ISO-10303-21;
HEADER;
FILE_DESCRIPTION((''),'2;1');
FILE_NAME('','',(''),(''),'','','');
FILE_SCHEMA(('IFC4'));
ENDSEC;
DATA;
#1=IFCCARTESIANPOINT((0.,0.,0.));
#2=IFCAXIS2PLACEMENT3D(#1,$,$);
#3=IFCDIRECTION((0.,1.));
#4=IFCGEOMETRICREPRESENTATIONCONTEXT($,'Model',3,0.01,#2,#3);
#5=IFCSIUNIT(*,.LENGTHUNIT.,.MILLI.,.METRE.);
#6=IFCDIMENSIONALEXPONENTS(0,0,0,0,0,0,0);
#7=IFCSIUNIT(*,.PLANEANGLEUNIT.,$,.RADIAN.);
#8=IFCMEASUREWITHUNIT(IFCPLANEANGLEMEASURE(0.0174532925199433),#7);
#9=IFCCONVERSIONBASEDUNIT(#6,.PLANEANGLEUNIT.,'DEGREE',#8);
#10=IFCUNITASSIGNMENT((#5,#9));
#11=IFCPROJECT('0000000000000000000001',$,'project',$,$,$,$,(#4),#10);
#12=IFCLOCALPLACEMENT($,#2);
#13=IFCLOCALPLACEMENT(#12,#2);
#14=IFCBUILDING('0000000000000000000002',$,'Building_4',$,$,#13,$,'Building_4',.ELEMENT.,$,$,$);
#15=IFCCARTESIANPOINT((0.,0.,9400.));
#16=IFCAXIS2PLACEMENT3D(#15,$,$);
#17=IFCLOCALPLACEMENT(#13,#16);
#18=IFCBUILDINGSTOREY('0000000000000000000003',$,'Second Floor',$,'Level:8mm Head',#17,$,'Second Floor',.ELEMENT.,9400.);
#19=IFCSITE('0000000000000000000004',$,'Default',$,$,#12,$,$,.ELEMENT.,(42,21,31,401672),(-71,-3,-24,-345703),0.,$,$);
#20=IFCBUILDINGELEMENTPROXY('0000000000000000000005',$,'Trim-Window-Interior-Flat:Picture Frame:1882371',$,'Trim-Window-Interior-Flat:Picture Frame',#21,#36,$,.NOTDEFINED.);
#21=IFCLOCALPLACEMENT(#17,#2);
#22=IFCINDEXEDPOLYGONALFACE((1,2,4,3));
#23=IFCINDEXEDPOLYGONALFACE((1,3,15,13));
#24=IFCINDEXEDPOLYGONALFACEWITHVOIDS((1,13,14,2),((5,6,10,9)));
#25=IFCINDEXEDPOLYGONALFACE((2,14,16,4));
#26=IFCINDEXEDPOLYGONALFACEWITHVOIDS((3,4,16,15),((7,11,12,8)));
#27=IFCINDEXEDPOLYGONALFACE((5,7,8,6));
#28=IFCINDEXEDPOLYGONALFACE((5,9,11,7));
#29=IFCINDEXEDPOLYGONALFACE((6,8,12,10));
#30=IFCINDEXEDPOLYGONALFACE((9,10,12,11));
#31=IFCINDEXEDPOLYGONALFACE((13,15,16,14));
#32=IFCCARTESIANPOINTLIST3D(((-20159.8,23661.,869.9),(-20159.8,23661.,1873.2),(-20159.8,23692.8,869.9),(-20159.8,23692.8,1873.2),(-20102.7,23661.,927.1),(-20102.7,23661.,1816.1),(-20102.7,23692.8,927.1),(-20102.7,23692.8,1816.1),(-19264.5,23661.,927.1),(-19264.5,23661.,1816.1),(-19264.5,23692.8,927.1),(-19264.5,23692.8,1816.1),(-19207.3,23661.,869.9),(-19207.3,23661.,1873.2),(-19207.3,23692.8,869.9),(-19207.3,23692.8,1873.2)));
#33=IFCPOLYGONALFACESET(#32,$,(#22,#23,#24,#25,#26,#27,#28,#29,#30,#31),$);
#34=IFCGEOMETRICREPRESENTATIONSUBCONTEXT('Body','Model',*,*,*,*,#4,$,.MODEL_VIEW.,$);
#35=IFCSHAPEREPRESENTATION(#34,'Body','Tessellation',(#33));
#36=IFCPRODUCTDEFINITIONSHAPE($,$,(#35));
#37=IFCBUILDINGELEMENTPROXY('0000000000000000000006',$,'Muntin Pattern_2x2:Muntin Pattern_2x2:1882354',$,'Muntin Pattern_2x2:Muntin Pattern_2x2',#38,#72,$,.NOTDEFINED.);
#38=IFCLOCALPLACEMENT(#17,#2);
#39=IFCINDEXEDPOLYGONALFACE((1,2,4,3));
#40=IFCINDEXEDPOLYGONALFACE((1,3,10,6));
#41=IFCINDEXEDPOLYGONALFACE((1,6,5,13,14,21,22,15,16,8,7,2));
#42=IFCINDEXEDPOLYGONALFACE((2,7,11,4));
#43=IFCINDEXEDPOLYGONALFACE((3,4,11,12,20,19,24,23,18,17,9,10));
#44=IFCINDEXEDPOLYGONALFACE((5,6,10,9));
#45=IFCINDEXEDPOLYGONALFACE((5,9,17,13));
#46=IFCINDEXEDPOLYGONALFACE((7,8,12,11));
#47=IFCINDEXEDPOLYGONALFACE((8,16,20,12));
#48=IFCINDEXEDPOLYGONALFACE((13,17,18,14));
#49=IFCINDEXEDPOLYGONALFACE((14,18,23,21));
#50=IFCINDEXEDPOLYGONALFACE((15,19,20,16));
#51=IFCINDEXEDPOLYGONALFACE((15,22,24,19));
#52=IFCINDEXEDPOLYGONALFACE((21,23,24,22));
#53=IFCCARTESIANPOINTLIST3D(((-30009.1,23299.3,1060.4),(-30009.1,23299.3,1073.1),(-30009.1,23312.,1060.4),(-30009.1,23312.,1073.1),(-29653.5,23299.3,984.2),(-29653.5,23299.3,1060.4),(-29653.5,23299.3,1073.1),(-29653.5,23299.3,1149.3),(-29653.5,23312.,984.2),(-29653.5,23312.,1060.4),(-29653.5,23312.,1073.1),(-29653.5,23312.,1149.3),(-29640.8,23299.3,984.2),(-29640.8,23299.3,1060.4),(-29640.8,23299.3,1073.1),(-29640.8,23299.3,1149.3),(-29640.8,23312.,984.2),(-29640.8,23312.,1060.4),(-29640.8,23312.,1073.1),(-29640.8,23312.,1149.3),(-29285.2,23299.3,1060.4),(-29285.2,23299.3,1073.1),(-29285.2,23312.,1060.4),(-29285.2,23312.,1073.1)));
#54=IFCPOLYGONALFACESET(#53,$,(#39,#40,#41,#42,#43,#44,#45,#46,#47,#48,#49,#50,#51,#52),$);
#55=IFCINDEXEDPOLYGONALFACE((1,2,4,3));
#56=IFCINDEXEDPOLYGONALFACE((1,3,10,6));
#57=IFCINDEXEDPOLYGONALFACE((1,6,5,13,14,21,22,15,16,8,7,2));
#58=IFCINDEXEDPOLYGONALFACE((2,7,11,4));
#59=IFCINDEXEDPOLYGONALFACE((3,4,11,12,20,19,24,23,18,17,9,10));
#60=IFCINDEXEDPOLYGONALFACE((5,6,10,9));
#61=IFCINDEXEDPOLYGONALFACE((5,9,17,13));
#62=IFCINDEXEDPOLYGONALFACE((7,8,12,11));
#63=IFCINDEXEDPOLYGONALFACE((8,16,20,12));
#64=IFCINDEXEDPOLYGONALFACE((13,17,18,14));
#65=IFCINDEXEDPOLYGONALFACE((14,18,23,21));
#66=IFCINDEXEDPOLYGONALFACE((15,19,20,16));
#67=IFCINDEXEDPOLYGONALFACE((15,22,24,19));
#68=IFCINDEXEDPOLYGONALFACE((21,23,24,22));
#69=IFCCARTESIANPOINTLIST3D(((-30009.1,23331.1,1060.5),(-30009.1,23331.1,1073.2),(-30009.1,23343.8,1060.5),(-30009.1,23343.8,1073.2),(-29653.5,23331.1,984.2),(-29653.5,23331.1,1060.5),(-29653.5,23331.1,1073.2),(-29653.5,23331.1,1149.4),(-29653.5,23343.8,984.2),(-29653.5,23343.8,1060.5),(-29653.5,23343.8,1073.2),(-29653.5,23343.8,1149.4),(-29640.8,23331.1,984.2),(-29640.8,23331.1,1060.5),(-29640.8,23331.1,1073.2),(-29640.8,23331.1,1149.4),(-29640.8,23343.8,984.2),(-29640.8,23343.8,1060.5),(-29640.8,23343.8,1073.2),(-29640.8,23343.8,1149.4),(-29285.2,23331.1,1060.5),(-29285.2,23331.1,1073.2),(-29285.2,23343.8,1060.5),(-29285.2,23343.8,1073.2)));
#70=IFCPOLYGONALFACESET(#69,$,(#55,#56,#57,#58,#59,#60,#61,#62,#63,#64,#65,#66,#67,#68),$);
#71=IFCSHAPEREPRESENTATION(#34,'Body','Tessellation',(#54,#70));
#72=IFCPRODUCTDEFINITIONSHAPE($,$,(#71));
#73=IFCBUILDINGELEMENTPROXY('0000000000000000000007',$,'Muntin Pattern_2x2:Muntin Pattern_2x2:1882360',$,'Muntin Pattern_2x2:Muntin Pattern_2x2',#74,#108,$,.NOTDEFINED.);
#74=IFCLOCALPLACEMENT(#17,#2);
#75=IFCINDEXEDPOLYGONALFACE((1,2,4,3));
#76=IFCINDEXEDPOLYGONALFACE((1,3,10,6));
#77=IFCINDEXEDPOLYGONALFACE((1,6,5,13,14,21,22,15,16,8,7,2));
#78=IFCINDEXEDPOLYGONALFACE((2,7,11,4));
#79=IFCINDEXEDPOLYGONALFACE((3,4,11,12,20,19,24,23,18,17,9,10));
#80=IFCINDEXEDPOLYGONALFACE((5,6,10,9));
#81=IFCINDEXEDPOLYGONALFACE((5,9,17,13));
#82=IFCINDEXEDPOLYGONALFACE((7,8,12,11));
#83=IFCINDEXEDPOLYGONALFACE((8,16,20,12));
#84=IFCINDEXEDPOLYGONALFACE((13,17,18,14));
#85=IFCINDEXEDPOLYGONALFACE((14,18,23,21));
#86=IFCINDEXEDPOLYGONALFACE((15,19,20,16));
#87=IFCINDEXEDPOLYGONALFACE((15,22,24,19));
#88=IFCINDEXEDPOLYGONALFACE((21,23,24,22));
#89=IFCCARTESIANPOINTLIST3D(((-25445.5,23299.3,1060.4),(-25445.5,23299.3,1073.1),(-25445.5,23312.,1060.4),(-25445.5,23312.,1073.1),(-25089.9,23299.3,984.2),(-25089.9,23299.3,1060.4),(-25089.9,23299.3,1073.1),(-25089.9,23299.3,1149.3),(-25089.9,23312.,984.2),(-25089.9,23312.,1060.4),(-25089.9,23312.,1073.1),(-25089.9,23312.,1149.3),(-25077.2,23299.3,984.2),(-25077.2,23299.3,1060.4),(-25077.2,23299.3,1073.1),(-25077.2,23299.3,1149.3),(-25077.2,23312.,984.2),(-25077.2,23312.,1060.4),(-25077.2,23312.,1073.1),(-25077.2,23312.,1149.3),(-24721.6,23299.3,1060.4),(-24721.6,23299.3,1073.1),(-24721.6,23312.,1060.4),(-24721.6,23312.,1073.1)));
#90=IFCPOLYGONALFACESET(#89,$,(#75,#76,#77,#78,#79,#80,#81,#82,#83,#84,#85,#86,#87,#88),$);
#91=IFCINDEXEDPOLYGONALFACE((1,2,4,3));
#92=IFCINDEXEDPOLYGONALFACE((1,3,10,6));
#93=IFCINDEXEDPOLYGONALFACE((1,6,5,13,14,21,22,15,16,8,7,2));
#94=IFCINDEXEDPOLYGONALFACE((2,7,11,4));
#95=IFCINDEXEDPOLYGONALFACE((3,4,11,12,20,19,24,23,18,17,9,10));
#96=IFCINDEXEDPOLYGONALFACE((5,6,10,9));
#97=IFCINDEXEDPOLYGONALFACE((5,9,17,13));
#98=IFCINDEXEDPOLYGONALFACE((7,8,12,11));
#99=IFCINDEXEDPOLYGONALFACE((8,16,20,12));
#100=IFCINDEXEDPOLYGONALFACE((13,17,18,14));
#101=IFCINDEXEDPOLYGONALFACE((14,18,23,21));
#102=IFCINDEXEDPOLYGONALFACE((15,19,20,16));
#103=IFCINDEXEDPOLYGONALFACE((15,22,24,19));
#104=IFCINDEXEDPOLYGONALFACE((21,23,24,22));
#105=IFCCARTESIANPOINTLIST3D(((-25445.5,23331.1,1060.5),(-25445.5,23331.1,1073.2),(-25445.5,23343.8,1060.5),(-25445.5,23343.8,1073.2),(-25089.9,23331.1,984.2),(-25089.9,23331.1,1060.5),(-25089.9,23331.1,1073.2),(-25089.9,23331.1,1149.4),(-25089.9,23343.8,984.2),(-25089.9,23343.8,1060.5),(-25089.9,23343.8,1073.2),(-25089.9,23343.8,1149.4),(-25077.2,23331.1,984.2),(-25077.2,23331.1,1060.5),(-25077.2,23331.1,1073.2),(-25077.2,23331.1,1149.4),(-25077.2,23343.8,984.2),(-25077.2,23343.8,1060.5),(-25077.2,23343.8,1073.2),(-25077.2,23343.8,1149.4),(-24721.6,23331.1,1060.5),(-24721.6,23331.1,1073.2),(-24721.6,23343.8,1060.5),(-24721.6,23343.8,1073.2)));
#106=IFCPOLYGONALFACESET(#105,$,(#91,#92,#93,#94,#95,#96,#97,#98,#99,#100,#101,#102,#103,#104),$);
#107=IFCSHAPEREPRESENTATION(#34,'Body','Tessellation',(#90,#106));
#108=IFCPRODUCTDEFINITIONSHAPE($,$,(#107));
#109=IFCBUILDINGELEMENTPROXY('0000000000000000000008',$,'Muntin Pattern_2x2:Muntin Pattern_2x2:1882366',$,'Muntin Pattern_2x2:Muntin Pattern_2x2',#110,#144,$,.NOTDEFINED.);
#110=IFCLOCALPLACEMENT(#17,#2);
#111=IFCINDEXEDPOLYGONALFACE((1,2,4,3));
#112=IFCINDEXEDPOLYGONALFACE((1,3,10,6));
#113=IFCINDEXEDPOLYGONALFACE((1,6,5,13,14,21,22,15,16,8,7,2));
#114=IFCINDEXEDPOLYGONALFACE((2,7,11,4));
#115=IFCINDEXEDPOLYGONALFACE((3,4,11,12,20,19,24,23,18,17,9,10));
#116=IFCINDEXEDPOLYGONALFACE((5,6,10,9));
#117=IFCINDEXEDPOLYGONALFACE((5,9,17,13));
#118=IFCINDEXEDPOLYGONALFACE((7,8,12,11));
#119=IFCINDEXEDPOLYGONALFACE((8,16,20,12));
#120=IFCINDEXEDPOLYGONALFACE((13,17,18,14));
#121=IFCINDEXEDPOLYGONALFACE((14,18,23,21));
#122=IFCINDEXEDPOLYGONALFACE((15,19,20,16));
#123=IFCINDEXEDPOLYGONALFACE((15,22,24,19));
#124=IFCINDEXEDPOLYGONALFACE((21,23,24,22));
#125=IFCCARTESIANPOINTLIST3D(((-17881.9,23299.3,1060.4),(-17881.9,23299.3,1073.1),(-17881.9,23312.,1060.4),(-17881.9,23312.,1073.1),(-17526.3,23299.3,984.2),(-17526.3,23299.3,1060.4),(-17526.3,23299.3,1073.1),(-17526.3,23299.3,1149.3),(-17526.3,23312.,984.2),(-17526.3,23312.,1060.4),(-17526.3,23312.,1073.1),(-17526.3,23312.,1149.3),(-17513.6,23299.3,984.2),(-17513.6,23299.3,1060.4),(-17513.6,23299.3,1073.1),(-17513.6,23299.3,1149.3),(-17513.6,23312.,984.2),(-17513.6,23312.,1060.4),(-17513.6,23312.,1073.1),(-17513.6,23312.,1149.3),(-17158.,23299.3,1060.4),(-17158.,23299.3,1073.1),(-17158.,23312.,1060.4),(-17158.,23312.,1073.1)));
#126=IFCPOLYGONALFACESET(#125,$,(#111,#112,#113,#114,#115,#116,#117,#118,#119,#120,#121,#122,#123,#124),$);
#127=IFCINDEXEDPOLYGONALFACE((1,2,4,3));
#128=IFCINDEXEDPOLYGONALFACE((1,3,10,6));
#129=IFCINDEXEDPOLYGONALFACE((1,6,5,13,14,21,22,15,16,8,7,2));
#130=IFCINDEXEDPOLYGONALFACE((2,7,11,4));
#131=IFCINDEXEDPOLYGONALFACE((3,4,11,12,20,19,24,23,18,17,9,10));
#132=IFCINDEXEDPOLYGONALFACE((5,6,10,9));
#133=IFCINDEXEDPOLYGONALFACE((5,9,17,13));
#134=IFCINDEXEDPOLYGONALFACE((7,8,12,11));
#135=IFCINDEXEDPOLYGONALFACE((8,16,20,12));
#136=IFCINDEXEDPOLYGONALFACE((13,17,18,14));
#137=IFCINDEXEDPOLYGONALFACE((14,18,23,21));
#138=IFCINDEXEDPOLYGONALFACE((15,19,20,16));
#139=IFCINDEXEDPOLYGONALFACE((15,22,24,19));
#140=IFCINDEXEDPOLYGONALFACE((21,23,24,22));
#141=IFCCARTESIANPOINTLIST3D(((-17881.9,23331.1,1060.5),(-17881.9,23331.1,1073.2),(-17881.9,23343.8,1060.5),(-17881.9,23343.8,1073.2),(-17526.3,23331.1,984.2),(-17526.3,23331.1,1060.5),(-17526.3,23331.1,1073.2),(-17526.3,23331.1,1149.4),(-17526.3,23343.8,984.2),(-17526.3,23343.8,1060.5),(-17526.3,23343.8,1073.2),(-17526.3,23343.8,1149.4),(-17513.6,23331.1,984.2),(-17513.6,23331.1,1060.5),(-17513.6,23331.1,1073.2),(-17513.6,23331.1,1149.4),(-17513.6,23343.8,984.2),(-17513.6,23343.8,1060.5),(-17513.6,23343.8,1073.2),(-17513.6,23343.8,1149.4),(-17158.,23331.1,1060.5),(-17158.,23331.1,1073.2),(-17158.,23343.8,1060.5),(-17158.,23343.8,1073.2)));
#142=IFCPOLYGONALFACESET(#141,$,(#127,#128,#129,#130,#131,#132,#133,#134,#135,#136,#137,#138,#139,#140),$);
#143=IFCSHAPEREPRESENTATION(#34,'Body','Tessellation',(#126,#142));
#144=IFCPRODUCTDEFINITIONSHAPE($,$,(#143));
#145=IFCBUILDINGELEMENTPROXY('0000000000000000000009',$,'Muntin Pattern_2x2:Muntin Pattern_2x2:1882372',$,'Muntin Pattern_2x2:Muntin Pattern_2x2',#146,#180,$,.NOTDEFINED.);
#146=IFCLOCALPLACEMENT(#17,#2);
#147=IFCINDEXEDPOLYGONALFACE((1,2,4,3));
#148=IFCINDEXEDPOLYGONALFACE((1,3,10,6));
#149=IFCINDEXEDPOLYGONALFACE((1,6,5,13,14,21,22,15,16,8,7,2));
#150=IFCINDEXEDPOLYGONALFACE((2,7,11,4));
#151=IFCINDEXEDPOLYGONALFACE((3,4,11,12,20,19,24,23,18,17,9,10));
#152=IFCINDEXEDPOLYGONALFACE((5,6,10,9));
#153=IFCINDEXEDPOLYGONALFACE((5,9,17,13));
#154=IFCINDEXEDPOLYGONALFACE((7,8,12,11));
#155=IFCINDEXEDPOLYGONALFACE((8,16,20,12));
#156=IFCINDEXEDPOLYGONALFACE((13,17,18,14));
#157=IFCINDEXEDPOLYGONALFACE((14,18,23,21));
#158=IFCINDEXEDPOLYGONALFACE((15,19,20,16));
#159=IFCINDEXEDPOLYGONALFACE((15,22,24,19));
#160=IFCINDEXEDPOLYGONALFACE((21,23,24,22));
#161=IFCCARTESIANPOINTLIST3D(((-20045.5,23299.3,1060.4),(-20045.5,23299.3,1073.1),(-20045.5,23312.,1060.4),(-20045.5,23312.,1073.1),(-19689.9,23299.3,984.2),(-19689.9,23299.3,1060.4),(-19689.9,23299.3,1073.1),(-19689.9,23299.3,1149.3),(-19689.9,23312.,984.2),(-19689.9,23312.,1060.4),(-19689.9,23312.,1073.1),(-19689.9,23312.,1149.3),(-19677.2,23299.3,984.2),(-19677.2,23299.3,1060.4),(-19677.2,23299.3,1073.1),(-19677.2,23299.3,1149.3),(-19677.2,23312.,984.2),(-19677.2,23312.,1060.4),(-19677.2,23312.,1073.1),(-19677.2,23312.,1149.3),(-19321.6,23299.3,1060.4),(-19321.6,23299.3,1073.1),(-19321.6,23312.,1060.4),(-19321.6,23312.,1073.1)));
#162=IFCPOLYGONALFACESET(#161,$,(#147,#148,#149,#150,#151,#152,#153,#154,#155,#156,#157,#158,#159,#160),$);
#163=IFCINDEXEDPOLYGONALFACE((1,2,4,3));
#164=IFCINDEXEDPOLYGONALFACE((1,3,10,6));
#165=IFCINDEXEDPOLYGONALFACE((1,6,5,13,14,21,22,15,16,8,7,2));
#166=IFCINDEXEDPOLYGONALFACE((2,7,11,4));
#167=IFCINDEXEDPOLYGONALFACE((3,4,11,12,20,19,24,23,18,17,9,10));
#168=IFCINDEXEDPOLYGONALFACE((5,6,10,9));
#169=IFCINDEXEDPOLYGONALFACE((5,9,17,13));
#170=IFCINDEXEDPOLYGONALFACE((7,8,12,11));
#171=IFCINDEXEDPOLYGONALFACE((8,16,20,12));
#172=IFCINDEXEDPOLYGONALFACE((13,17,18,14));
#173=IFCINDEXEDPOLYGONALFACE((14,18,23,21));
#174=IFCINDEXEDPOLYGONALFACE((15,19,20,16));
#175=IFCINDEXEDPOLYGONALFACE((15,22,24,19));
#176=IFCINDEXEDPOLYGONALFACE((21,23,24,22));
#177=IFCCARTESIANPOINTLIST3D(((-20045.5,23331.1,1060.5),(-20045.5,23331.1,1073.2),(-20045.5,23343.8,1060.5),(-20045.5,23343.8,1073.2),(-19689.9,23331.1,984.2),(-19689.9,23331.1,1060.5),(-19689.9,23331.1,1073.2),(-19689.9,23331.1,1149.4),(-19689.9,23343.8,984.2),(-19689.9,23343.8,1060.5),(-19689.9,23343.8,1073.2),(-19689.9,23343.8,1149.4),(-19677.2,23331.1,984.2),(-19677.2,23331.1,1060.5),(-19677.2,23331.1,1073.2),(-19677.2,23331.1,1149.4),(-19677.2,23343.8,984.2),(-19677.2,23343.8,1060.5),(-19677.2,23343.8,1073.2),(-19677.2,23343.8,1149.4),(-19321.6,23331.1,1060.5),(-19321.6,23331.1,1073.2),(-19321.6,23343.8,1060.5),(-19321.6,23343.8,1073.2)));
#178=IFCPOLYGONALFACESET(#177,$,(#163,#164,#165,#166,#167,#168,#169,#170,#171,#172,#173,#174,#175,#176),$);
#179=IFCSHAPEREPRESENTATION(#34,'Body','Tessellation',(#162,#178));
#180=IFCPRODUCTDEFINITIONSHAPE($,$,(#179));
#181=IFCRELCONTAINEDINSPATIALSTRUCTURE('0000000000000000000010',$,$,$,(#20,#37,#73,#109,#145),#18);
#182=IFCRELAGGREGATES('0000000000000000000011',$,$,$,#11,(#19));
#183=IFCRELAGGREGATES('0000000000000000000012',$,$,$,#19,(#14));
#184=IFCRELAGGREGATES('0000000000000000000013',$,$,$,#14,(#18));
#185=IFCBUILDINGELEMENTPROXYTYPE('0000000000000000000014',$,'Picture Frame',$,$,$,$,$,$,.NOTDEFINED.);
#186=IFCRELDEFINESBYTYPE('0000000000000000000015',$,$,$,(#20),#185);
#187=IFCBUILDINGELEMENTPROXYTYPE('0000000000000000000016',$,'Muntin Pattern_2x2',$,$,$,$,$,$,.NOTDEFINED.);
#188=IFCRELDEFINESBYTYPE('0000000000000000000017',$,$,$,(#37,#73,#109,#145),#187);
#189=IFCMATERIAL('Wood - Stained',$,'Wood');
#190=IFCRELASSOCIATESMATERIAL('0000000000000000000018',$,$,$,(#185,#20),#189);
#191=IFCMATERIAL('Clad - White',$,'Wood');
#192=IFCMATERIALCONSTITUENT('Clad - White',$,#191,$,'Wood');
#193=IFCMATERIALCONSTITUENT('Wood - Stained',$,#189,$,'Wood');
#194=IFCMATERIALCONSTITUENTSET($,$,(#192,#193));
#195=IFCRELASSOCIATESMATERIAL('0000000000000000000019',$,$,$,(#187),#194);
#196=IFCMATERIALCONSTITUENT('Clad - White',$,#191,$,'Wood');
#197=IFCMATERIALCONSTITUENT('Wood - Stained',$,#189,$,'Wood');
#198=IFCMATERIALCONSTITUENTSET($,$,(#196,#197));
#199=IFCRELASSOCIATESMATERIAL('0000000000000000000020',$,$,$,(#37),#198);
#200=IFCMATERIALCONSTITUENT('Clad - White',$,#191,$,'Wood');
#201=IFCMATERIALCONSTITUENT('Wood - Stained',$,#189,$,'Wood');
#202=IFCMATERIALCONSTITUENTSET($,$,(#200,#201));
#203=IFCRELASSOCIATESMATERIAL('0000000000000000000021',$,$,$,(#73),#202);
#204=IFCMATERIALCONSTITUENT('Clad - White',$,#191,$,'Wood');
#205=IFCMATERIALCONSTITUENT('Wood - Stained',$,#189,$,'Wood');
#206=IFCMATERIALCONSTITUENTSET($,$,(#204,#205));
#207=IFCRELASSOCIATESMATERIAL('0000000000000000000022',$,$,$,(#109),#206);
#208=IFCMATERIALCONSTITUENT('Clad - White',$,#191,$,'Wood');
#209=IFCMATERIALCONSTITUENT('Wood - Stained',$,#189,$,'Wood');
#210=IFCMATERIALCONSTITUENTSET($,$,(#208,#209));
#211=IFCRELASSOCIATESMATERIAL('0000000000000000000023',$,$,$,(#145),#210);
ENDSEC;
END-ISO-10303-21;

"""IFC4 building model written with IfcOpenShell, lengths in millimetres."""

from ifc_helpers import new_model, entity, si_unit, converted_unit, direction, frame, origin, place, context, subcontext, project, spatial, indexed_curve, outline, extrude, source, transform, mapped, material, constituent, constituent_set, type_object, type_shapes, element, save


model = new_model("IFC4")

# Units and contexts
model_context = context("Model", 3, precision=0.01, world=origin(), true_north=direction((0.0, 1.0)))
body_context = subcontext(model_context, "Body", "Model", "MODEL_VIEW")
ifc_project = project(units=[si_unit("LENGTHUNIT", "METRE", prefix="MILLI"), converted_unit("PLANEANGLEUNIT", "DEGREE", entity("IfcPlaneAngleMeasure", 0.0174532925199433), si_unit("PLANEANGLEUNIT", "RADIAN"), dimensions=[0, 0, 0, 0, 0, 0, 0])], contexts=[model_context])

# Site, building, storey
site_placement = place(None, origin())
site = spatial("IfcSite", under=ifc_project, at=site_placement, Name="Default", CompositionType="ELEMENT", RefLatitude=(42, 21, 31, 401672), RefLongitude=(-71, -3, -24, -345703), RefElevation=0.0)
building_placement = place(site_placement, origin())
building = spatial("IfcBuilding", under=site, at=building_placement, Name="Building_4", LongName="Building_4", CompositionType="ELEMENT")
storey_placement = place(building_placement, frame((0.0, 0.0, 9400.0)))
storey = spatial("IfcBuildingStorey", under=building, at=storey_placement, Name="Second Floor", ObjectType="Level:8mm Head", LongName="Second Floor", CompositionType="ELEMENT", Elevation=9400.0)

# Shared definitions
ifc_material_1 = material(Name="Clad - White", Category="Wood")
ifc_material_2 = material(Name="Wood - Stained", Category="Wood")

# Building element proxies
building_element_proxy_type_1 = type_object("IfcBuildingElementProxyType", Name="Picture Frame", PredefinedType="NOTDEFINED", material=ifc_material_2)
shared_shape_1 = source(origin(), body_context, "Body", "SweptSolid", [
    extrude(outline(indexed_curve([(-476.2, -501.6), (476.2, -501.6), (476.2, 501.6), (-476.2, 501.6), (-476.2, -501.6)], self_intersect=False), holes=[indexed_curve([(-419.1, -444.5), (-419.1, 444.5), (419.1, 444.5), (419.1, -444.5), (-419.1, -444.5)], self_intersect=False)]), frame((0.0, -457.2, 0.0), z_axis=(0.0, 0.0, 1.0), x_axis=(-1.0, 0.0, 0.0)), (0.0, 0.0, 1.0), 31.8),
])
type_shapes(building_element_proxy_type_1, [shared_shape_1])
for number, where, z_axis, x_axis, name in (
    (1, (-19683.6, 23661.0, 1828.8), (0.0, 1.0, 0.0), (-1.0, 0.0, 0.0), "Trim-Window-Interior-Flat:Picture Frame:1882371"),
):
    element("IfcBuildingElementProxy", number, at=place(storey_placement, frame(where, z_axis=z_axis, x_axis=x_axis)), inside=storey, type_object=building_element_proxy_type_1, material=ifc_material_2, Name=name, ObjectType="Trim-Window-Interior-Flat:Picture Frame", PredefinedType="NOTDEFINED", context=body_context, shape_type="MappedRepresentation", body=[
        mapped(shared_shape_1, transform((0.0, 0.0, 0.0), scale=1.0)),
    ])
ifc_constituent_1 = constituent(ifc_material_1, Name="Clad - White", Category="Wood")
ifc_constituent_2 = constituent(ifc_material_2, Name="Wood - Stained", Category="Wood")
ifc_constituent_set_1 = constituent_set(constituents=[ifc_constituent_1, ifc_constituent_2])
ifc_constituent_3 = constituent(ifc_material_1, Name="Clad - White", Category="Wood")
ifc_constituent_4 = constituent(ifc_material_2, Name="Wood - Stained", Category="Wood")
ifc_constituent_set_2 = constituent_set(constituents=[ifc_constituent_3, ifc_constituent_4])
building_element_proxy_type_2 = type_object("IfcBuildingElementProxyType", Name="Muntin Pattern_2x2", PredefinedType="NOTDEFINED", material=ifc_constituent_set_2)
shared_shape_2 = source(origin(), body_context, "Body", "SweptSolid", [
    extrude(outline(indexed_curve([(6.4, -6.4), (82.5, -6.4), (82.5, 6.3), (6.4, 6.3), (6.4, 362.0), (-6.3, 362.0), (-6.3, 6.3), (-82.6, 6.3), (-82.6, -6.4), (-6.3, -6.4), (-6.3, -361.9), (6.4, -361.9), (6.4, -6.4)], self_intersect=False)), frame((0.0, -22.2, 82.5), z_axis=(0.0, 1.0, 0.0), x_axis=(0.0, 0.0, 1.0)), (0.0, 0.0, 1.0), 12.7),
    extrude(outline(indexed_curve([(6.4, -6.4), (82.6, -6.4), (82.6, 6.3), (6.4, 6.3), (6.4, 362.0), (-6.3, 362.0), (-6.3, 6.3), (-82.6, 6.3), (-82.6, -6.4), (-6.3, -6.4), (-6.3, -361.9), (6.4, -361.9), (6.4, -6.4)], self_intersect=False)), frame((0.0, 9.5, 82.6), z_axis=(0.0, 1.0, 0.0), x_axis=(0.0, 0.0, 1.0)), (0.0, 0.0, 1.0), 12.7),
])
type_shapes(building_element_proxy_type_2, [shared_shape_2])
proxy_1_placement = place(storey_placement, frame((-29647.2, 23321.5, 984.2)))
element("IfcBuildingElementProxy", 2, at=proxy_1_placement, inside=storey, type_object=building_element_proxy_type_2, material=ifc_constituent_set_1, Name="Muntin Pattern_2x2:Muntin Pattern_2x2:1882354", ObjectType="Muntin Pattern_2x2:Muntin Pattern_2x2", PredefinedType="NOTDEFINED", context=body_context, shape_type="MappedRepresentation", body=[
    mapped(shared_shape_2, transform((0.0, 0.0, 0.0), scale=1.0)),
])
ifc_constituent_5 = constituent(ifc_material_1, Name="Clad - White", Category="Wood")
ifc_constituent_6 = constituent(ifc_material_2, Name="Wood - Stained", Category="Wood")
ifc_constituent_set_3 = constituent_set(constituents=[ifc_constituent_5, ifc_constituent_6])
proxy_2_placement = place(storey_placement, frame((-25083.6, 23321.5, 984.2)))
element("IfcBuildingElementProxy", 3, at=proxy_2_placement, inside=storey, type_object=building_element_proxy_type_2, material=ifc_constituent_set_3, Name="Muntin Pattern_2x2:Muntin Pattern_2x2:1882360", ObjectType="Muntin Pattern_2x2:Muntin Pattern_2x2", PredefinedType="NOTDEFINED", context=body_context, shape_type="MappedRepresentation", body=[
    mapped(shared_shape_2, transform((0.0, 0.0, 0.0), scale=1.0)),
])
ifc_constituent_7 = constituent(ifc_material_1, Name="Clad - White", Category="Wood")
ifc_constituent_8 = constituent(ifc_material_2, Name="Wood - Stained", Category="Wood")
ifc_constituent_set_4 = constituent_set(constituents=[ifc_constituent_7, ifc_constituent_8])
proxy_3_placement = place(storey_placement, frame((-17520.0, 23321.5, 984.2)))
element("IfcBuildingElementProxy", 4, at=proxy_3_placement, inside=storey, type_object=building_element_proxy_type_2, material=ifc_constituent_set_4, Name="Muntin Pattern_2x2:Muntin Pattern_2x2:1882366", ObjectType="Muntin Pattern_2x2:Muntin Pattern_2x2", PredefinedType="NOTDEFINED", context=body_context, shape_type="MappedRepresentation", body=[
    mapped(shared_shape_2, transform((0.0, 0.0, 0.0), scale=1.0)),
])
ifc_constituent_9 = constituent(ifc_material_1, Name="Clad - White", Category="Wood")
ifc_constituent_10 = constituent(ifc_material_2, Name="Wood - Stained", Category="Wood")
ifc_constituent_set_5 = constituent_set(constituents=[ifc_constituent_9, ifc_constituent_10])
proxy_4_placement = place(storey_placement, frame((-19683.6, 23321.5, 984.2)))
element("IfcBuildingElementProxy", 5, at=proxy_4_placement, inside=storey, type_object=building_element_proxy_type_2, material=ifc_constituent_set_5, Name="Muntin Pattern_2x2:Muntin Pattern_2x2:1882372", ObjectType="Muntin Pattern_2x2:Muntin Pattern_2x2", PredefinedType="NOTDEFINED", context=body_context, shape_type="MappedRepresentation", body=[
    mapped(shared_shape_2, transform((0.0, 0.0, 0.0), scale=1.0)),
])

save(model, "model.ifc")
